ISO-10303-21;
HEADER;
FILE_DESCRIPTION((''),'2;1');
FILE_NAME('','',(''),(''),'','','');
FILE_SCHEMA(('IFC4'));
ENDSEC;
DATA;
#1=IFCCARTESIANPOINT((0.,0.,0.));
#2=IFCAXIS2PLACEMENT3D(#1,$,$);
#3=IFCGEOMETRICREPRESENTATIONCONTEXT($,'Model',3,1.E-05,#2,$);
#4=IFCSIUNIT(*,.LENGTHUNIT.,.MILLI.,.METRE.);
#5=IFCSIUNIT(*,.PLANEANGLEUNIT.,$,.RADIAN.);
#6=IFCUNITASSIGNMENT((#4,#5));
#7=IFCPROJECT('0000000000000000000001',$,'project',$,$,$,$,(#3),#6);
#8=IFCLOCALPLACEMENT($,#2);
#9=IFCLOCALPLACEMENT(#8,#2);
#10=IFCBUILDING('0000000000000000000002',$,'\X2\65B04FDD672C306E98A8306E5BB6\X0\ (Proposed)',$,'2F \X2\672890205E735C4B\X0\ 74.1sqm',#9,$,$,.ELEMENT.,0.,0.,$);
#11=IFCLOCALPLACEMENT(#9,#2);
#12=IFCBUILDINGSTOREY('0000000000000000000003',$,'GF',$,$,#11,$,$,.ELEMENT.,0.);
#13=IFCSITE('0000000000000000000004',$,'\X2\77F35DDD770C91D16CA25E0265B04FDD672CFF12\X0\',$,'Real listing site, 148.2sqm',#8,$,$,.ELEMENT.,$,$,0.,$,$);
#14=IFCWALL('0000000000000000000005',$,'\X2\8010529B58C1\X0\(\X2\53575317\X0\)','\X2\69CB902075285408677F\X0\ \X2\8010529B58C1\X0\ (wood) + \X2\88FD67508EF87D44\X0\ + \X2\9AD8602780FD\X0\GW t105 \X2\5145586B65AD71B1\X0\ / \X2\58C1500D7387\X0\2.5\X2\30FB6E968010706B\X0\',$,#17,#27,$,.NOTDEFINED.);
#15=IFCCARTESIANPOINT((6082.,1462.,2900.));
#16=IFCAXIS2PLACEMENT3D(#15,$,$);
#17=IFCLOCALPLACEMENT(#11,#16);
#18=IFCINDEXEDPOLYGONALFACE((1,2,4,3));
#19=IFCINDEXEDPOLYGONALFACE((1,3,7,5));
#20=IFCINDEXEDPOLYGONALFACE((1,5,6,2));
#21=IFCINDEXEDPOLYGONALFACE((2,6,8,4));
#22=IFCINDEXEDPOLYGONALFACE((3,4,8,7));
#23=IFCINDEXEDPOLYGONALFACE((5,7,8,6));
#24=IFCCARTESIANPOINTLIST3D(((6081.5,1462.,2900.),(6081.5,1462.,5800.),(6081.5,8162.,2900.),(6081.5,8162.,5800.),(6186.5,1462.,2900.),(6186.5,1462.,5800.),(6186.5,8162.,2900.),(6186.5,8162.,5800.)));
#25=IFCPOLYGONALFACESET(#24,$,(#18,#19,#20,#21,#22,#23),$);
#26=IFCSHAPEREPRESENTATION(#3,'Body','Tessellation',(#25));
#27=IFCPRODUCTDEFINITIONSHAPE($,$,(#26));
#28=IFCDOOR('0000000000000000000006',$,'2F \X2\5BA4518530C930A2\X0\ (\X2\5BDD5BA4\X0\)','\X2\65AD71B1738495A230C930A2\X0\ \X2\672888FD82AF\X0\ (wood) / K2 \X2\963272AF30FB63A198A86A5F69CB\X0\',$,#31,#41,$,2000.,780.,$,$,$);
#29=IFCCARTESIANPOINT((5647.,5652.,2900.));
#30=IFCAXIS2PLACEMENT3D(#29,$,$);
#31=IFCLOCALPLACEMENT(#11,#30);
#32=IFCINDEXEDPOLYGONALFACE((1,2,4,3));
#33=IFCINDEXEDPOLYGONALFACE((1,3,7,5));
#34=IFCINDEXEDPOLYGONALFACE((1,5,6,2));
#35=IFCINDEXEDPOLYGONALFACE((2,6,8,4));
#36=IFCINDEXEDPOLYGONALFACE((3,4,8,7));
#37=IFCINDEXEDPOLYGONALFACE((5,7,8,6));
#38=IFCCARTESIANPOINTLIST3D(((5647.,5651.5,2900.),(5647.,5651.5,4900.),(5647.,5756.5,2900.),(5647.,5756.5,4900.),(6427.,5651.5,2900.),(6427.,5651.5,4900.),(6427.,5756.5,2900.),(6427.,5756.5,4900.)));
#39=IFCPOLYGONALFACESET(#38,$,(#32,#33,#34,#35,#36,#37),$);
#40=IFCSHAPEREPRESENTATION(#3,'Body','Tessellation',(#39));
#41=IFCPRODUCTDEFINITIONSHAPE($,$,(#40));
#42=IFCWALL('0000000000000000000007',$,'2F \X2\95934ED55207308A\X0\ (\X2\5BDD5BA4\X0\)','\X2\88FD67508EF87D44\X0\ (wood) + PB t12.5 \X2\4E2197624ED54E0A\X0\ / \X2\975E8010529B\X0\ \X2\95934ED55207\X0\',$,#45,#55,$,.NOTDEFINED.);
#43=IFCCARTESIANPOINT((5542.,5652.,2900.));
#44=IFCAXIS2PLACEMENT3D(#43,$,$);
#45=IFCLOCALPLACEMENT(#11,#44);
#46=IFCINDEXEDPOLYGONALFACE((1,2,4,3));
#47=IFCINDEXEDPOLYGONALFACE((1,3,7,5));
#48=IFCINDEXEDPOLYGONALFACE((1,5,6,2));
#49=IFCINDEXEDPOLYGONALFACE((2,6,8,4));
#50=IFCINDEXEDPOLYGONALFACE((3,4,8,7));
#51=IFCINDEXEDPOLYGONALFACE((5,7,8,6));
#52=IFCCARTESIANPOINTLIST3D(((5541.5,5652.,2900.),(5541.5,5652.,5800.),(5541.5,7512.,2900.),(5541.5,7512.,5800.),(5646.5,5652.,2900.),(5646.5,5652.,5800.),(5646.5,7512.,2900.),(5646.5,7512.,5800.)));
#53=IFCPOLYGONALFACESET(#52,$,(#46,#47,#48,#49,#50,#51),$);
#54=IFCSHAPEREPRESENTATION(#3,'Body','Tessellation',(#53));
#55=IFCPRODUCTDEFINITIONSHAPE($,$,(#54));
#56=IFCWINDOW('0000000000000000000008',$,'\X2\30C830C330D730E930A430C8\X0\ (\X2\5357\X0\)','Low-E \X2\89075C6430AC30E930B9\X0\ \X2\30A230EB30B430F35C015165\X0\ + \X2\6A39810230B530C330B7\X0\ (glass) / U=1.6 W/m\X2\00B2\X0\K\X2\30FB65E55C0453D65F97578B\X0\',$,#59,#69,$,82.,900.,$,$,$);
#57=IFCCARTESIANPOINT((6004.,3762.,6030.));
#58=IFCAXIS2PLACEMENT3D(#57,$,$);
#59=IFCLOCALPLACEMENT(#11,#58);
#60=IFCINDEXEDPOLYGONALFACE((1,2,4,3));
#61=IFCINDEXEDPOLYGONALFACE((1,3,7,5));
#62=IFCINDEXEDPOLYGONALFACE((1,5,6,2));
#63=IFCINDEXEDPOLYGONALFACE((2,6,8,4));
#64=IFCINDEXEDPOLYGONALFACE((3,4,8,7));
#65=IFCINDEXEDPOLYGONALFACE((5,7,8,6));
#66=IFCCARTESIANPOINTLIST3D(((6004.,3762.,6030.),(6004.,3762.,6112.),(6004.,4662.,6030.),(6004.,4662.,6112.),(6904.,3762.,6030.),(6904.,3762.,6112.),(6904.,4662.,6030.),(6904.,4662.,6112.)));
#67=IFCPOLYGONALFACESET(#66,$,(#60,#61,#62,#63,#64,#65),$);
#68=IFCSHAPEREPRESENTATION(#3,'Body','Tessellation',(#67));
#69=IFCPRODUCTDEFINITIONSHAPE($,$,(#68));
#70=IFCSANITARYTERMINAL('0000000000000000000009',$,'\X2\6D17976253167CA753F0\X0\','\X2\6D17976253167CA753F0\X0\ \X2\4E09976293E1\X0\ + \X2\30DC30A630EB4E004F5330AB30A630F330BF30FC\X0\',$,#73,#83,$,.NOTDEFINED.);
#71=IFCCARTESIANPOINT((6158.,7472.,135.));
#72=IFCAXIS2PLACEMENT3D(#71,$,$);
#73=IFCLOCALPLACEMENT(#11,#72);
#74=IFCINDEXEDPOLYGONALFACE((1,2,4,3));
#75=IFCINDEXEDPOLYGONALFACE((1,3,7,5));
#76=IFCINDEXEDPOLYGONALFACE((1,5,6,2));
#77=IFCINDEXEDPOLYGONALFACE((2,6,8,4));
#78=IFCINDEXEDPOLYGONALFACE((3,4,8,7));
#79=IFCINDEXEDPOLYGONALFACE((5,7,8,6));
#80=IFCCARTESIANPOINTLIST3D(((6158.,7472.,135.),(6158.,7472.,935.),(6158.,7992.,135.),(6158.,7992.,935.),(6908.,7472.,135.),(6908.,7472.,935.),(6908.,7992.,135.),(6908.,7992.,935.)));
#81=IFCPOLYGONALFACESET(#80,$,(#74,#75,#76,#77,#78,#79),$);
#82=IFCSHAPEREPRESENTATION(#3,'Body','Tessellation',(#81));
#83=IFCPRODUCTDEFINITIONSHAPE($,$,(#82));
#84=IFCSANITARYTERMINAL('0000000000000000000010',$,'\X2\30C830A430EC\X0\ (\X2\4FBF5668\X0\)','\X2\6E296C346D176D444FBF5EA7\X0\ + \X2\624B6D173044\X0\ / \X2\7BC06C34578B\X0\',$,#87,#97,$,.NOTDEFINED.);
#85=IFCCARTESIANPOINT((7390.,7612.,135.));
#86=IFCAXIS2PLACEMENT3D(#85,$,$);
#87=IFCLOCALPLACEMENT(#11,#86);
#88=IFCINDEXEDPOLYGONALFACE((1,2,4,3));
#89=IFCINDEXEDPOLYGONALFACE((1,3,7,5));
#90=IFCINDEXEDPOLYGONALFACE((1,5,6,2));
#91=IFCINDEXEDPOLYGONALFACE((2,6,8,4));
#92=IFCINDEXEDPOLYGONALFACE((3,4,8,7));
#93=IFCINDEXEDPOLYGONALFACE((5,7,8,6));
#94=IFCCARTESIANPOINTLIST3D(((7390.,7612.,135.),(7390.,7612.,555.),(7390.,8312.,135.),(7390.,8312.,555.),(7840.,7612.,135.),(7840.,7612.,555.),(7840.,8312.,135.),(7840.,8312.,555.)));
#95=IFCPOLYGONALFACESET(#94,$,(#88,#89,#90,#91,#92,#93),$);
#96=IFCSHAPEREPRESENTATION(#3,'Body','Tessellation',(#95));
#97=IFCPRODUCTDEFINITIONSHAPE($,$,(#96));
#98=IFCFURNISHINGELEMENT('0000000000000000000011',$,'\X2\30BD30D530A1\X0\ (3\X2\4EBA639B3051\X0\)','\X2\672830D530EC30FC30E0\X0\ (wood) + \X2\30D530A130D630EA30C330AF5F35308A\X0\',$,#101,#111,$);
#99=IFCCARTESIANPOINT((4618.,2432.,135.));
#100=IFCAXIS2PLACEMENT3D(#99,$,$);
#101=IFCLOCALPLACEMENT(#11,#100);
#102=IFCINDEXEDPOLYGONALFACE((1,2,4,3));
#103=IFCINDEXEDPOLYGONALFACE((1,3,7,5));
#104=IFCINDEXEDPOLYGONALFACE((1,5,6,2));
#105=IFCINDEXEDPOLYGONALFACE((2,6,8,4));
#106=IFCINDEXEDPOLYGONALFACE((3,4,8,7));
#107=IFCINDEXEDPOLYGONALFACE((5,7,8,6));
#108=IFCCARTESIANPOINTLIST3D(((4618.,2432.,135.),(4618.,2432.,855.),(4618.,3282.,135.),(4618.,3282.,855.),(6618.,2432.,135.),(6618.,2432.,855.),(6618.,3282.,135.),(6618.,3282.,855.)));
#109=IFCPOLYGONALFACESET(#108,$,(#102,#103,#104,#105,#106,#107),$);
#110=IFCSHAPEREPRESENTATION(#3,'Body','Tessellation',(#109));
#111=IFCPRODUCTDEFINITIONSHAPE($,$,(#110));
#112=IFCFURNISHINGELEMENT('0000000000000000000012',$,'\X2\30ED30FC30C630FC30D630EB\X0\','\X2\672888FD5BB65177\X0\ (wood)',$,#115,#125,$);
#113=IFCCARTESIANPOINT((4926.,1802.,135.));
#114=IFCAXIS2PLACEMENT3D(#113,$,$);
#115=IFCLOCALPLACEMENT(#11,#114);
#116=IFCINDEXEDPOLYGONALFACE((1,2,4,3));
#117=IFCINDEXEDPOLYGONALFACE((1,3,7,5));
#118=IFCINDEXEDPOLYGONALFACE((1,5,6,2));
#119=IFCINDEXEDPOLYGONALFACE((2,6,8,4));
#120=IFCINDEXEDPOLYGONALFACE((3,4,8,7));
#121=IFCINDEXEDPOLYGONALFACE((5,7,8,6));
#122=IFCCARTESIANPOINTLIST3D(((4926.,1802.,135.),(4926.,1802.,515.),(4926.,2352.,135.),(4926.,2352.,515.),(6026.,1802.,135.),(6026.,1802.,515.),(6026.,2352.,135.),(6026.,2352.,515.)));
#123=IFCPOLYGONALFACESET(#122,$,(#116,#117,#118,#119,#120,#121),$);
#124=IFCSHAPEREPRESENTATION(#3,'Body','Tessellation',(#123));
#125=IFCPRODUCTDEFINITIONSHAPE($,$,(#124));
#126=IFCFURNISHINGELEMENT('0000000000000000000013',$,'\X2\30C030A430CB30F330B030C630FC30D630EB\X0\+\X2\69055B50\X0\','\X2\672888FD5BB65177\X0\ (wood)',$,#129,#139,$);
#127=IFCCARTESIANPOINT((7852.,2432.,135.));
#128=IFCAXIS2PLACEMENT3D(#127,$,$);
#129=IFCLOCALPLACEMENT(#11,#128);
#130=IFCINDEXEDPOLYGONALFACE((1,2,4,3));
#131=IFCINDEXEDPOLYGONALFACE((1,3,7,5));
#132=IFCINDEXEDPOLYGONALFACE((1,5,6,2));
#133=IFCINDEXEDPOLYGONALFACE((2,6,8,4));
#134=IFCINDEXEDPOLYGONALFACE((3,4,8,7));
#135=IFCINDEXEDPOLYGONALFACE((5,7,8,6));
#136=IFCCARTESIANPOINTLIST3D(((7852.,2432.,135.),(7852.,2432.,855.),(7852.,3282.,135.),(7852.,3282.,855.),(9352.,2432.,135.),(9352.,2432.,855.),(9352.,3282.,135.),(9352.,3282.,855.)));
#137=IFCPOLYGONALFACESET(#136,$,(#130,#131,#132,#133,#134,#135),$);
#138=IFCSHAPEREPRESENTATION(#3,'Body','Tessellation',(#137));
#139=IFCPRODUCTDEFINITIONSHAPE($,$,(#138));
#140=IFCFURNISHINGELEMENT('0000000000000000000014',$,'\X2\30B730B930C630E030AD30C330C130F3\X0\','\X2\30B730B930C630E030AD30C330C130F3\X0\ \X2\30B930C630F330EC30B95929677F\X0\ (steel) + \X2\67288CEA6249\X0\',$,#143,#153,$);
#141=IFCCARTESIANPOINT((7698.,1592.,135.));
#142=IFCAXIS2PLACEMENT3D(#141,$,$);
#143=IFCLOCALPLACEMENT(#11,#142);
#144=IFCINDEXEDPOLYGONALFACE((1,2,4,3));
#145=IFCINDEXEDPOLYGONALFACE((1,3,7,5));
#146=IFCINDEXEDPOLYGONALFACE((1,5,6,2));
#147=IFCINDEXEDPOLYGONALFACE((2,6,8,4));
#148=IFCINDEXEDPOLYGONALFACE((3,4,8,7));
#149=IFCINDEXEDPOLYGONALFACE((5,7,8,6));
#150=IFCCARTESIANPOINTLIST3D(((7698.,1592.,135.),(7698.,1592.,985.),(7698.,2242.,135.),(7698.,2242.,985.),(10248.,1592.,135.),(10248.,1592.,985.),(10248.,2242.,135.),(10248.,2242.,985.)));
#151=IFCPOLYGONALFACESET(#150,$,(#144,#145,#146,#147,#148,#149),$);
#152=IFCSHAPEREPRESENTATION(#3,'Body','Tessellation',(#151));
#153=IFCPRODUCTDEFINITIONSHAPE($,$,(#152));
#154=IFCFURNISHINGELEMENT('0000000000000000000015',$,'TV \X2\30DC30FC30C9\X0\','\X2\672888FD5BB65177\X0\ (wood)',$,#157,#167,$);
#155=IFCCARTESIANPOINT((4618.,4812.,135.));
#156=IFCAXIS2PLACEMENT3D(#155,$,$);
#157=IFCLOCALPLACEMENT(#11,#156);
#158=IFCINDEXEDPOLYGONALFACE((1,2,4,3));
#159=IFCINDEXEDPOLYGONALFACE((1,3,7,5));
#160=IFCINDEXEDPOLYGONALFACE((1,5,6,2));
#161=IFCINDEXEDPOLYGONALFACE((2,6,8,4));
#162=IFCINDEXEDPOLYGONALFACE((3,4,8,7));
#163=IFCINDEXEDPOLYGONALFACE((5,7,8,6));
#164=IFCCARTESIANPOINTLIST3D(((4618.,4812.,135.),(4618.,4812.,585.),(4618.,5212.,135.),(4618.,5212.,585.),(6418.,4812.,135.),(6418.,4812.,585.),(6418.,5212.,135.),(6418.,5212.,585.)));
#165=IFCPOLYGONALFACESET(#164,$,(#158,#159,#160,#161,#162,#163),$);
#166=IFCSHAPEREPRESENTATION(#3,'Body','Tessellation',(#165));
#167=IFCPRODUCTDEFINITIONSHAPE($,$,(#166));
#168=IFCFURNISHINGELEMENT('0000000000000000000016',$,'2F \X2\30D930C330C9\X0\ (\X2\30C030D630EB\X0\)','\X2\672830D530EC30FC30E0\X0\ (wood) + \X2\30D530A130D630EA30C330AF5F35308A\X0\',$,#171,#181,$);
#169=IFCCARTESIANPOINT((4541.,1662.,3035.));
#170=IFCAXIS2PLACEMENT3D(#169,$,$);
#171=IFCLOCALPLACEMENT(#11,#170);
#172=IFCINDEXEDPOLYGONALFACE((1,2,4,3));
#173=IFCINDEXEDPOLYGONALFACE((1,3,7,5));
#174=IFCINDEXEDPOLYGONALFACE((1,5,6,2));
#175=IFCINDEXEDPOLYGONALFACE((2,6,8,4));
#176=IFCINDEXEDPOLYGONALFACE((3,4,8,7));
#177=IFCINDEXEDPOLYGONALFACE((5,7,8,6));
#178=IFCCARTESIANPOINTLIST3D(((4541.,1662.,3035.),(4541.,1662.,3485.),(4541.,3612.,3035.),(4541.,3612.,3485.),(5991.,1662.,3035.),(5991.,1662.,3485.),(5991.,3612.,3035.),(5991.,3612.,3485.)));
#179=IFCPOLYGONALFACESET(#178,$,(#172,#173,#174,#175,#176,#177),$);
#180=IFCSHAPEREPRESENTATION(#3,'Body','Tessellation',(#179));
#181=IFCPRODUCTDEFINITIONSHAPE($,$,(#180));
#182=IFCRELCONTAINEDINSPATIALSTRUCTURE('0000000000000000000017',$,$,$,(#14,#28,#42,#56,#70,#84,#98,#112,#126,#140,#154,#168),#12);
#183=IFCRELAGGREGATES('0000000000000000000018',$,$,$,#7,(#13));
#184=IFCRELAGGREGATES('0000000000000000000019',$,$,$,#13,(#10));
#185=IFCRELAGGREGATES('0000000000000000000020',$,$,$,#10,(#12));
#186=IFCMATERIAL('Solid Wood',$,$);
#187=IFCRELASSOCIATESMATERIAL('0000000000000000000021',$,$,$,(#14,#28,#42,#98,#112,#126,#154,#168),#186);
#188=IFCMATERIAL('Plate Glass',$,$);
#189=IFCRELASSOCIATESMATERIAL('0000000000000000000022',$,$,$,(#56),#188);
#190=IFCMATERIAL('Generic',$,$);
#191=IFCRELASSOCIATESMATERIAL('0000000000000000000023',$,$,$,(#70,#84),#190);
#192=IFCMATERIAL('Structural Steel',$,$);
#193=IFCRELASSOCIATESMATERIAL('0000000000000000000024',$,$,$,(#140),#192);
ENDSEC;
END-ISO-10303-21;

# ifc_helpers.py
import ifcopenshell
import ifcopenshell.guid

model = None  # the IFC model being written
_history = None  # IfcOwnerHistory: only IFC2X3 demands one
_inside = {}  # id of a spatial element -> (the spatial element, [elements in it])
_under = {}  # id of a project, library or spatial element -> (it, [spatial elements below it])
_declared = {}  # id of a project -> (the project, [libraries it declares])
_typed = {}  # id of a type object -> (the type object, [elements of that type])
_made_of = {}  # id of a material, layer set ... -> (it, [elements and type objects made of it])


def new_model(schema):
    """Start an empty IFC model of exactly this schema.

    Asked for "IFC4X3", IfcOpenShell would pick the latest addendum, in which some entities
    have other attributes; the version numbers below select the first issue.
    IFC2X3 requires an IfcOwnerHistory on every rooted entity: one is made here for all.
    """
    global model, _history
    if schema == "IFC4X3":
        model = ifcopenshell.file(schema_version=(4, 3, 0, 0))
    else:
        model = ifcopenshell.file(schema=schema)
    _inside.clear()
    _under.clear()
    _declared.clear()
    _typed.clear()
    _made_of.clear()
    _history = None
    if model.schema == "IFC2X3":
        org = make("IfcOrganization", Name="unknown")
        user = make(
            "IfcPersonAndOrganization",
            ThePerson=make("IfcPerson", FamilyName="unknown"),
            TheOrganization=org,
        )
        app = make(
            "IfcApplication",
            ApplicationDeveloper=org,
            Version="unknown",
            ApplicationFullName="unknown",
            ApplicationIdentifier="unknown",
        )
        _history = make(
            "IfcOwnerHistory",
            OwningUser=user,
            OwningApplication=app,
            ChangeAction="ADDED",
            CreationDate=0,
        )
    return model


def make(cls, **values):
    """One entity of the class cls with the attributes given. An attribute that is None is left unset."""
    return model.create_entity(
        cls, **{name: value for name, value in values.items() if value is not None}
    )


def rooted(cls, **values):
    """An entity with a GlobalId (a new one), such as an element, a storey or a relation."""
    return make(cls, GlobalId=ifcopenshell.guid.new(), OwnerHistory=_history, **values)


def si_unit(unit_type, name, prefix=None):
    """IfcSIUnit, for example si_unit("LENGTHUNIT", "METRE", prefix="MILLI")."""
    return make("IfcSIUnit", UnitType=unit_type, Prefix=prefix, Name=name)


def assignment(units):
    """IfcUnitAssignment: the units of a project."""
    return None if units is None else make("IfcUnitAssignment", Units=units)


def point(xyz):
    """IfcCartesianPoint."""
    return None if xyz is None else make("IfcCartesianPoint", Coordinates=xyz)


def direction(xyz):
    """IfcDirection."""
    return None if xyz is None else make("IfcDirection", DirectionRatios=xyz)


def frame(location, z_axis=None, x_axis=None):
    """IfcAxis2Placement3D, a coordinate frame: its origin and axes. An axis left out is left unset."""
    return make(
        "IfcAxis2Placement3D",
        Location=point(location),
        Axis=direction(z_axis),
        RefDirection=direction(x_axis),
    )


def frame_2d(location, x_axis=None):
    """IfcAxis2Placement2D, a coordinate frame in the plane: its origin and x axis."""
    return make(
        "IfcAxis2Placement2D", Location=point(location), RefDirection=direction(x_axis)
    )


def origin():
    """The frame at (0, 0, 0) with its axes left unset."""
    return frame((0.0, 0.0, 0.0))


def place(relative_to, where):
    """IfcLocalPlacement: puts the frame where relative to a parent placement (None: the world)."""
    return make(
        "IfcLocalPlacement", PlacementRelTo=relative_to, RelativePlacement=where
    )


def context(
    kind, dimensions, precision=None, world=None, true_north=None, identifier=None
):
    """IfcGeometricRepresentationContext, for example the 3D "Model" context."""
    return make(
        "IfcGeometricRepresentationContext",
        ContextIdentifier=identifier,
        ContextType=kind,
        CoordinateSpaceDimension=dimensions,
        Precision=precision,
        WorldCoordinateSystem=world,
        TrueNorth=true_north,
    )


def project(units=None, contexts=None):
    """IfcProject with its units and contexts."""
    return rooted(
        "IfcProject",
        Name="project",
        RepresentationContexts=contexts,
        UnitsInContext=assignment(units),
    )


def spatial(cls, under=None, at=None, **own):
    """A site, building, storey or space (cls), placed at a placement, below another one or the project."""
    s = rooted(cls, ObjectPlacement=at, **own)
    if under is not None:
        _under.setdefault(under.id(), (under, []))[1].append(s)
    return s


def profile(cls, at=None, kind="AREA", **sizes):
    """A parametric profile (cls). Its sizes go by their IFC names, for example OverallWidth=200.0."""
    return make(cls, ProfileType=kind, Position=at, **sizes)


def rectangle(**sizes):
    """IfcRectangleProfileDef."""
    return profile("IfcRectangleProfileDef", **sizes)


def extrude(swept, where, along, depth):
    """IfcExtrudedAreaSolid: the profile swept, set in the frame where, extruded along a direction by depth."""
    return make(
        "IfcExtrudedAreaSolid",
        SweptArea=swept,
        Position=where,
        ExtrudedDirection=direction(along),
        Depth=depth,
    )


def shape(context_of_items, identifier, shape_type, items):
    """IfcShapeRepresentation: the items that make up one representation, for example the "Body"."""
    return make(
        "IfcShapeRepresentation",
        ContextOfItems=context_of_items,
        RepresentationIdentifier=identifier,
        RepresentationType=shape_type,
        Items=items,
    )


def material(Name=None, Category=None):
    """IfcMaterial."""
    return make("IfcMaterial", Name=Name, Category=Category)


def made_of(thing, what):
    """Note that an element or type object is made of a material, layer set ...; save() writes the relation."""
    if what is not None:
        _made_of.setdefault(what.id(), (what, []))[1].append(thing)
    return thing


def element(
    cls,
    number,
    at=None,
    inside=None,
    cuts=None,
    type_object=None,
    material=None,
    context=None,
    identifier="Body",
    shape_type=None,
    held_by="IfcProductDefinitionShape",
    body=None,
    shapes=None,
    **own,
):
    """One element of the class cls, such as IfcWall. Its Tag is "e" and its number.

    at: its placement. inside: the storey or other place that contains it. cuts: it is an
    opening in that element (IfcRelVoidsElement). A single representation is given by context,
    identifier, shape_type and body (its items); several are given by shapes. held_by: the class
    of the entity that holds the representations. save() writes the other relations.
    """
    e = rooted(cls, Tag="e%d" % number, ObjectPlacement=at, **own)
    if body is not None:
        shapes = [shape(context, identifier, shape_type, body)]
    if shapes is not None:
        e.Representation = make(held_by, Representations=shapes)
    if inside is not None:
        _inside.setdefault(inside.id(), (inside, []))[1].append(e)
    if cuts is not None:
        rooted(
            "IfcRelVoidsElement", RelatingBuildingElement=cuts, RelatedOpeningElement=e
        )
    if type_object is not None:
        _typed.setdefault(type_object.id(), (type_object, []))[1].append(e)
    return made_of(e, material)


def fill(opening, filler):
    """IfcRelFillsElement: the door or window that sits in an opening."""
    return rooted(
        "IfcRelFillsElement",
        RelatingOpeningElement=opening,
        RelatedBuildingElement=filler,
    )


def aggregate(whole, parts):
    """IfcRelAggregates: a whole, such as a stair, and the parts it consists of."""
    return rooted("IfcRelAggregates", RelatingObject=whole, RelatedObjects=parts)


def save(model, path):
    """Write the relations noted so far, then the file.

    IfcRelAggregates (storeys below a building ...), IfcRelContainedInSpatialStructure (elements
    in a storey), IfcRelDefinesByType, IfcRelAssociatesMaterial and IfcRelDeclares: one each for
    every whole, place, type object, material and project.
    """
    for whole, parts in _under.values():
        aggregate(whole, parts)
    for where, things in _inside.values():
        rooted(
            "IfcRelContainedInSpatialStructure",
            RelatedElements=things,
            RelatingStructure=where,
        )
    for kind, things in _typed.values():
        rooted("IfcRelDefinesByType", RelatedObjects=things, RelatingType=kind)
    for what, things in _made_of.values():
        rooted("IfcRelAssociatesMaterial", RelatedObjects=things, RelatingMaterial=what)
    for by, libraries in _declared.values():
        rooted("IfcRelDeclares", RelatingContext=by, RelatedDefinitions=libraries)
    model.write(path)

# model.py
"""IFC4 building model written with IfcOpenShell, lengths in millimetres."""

from ifc_helpers import new_model, si_unit, frame, frame_2d, origin, place, context, project, spatial, rectangle, extrude, material, element, fill, save


model = new_model("IFC4")

# Units and contexts
model_context = context("Model", 3, precision=1e-05, world=origin())
ifc_project = project(units=[si_unit("LENGTHUNIT", "METRE", prefix="MILLI"), si_unit("PLANEANGLEUNIT", "RADIAN")], contexts=[model_context])

# Site, building, storey
site_placement = place(None, origin())
site = spatial("IfcSite", under=ifc_project, at=site_placement, Name="石川県金沢市新保本２", ObjectType="Real listing site, 148.2sqm", CompositionType="ELEMENT", RefElevation=0.0)
building_placement = place(site_placement, origin())
building = spatial("IfcBuilding", under=site, at=building_placement, Name="新保本の風の家 (Proposed)", ObjectType="2F 木造平屋 74.1sqm", CompositionType="ELEMENT", ElevationOfRefHeight=0.0, ElevationOfTerrain=0.0)
storey_placement = place(building_placement, origin())
storey = spatial("IfcBuildingStorey", under=building, at=storey_placement, Name="GF", CompositionType="ELEMENT", Elevation=0.0)

# Shared definitions
ifc_material_1 = material(Name="Solid Wood")

# Wall, opening, door
wall_1_placement = place(storey_placement, frame((6082.0, 1462.0, 2900.0)))
wall_1 = element("IfcWall", 1, at=wall_1_placement, inside=storey, material=ifc_material_1, Name="耐力壁(南北)", Description="構造用合板 耐力壁 (wood) + 製材軸組 + 高性能GW t105 充填断熱 / 壁倍率2.5・準耐火", PredefinedType="NOTDEFINED", context=model_context, shape_type="SweptSolid", body=[
    extrude(rectangle(XDim=105.0, YDim=6700.0, at=frame_2d((52.0, 3350.0))), frame((6082.0, 1462.0, 2900.0)), (0.0, 0.0, 1.0), 2900.0),
])
opening_1_placement = place(storey_placement, frame((5647.0, 5652.0, 2900.0)))
opening_1 = element("IfcOpeningElement", 2, at=opening_1_placement, cuts=wall_1, PredefinedType="NOTDEFINED", context=model_context, shape_type="SweptSolid", body=[
    extrude(rectangle(XDim=780.0, YDim=105.0, at=frame_2d((390.0, 52.0))), frame((5647.0, 5652.0, 2900.0)), (0.0, 0.0, 1.0), 2000.0),
])
door_1_placement = place(storey_placement, frame((5647.0, 5652.0, 2900.0)))
door_1 = element("IfcDoor", 3, at=door_1_placement, inside=storey, material=ifc_material_1, Name="2F 室内ドア (寝室)", Description="断熱玄関ドア 木製芯 (wood) / K2 防犯・採風機構", OverallHeight=2000.0, OverallWidth=780.0, context=model_context, shape_type="SweptSolid", body=[
    extrude(rectangle(XDim=780.0, YDim=105.0, at=frame_2d((390.0, 52.0))), frame((5647.0, 5652.0, 2900.0)), (0.0, 0.0, 1.0), 2000.0),
])
fill(opening_1, door_1)

# Wall
wall_2_placement = place(storey_placement, frame((5542.0, 5652.0, 2900.0)))
element("IfcWall", 4, at=wall_2_placement, inside=storey, material=ifc_material_1, Name="2F 間仕切り (寝室)", Description="製材軸組 (wood) + PB t12.5 両面仕上 / 非耐力 間仕切", PredefinedType="NOTDEFINED", context=model_context, shape_type="SweptSolid", body=[
    extrude(rectangle(XDim=105.0, YDim=1860.0, at=frame_2d((52.0, 930.0))), frame((5542.0, 5652.0, 2900.0)), (0.0, 0.0, 1.0), 2900.0),
])

# Window
ifc_material_2 = material(Name="Plate Glass")
window_placement = place(storey_placement, frame((6004.0, 3762.0, 6030.0)))
element("IfcWindow", 5, at=window_placement, inside=storey, material=ifc_material_2, Name="トップライト (南)", Description="Low-E 複層ガラス アルゴン封入 + 樹脂サッシ (glass) / U=1.6 W/m²K・日射取得型", OverallHeight=82.0, OverallWidth=900.0, context=model_context, shape_type="SweptSolid", body=[
    extrude(rectangle(XDim=900.0, YDim=900.0, at=frame_2d((450.0, 450.0))), frame((6004.0, 3762.0, 6030.0)), (0.0, 0.0, 1.0), 82.0),
])

# Sanitary terminals
ifc_material_3 = material(Name="Generic")
sanitary_terminal_1_placement = place(storey_placement, frame((6158.0, 7472.0, 135.0)))
element("IfcSanitaryTerminal", 6, at=sanitary_terminal_1_placement, inside=storey, material=ifc_material_3, Name="洗面化粧台", Description="洗面化粧台 三面鏡 + ボウル一体カウンター", PredefinedType="NOTDEFINED", context=model_context, shape_type="SweptSolid", body=[
    extrude(rectangle(XDim=750.0, YDim=520.0, at=frame_2d((375.0, 260.0))), frame((6158.0, 7472.0, 135.0)), (0.0, 0.0, 1.0), 800.0),
])
sanitary_terminal_2_placement = place(storey_placement, frame((7390.0, 7612.0, 135.0)))
element("IfcSanitaryTerminal", 7, at=sanitary_terminal_2_placement, inside=storey, material=ifc_material_3, Name="トイレ (便器)", Description="温水洗浄便座 + 手洗い / 節水型", PredefinedType="NOTDEFINED", context=model_context, shape_type="SweptSolid", body=[
    extrude(rectangle(XDim=450.0, YDim=700.0, at=frame_2d((225.0, 350.0))), frame((7390.0, 7612.0, 135.0)), (0.0, 0.0, 1.0), 420.0),
])

# Furnishing elements
furnishing_1_placement = place(storey_placement, frame((4618.0, 2432.0, 135.0)))
element("IfcFurnishingElement", 8, at=furnishing_1_placement, inside=storey, material=ifc_material_1, Name="ソファ (3人掛け)", Description="木フレーム (wood) + ファブリック張り", context=model_context, shape_type="SweptSolid", body=[
    extrude(rectangle(XDim=2000.0, YDim=850.0, at=frame_2d((1000.0, 425.0))), frame((4618.0, 2432.0, 135.0)), (0.0, 0.0, 1.0), 720.0),
])
furnishing_2_placement = place(storey_placement, frame((4926.0, 1802.0, 135.0)))
element("IfcFurnishingElement", 9, at=furnishing_2_placement, inside=storey, material=ifc_material_1, Name="ローテーブル", Description="木製家具 (wood)", context=model_context, shape_type="SweptSolid", body=[
    extrude(rectangle(XDim=1100.0, YDim=550.0, at=frame_2d((550.0, 275.0))), frame((4926.0, 1802.0, 135.0)), (0.0, 0.0, 1.0), 380.0),
])
furnishing_3_placement = place(storey_placement, frame((7852.0, 2432.0, 135.0)))
element("IfcFurnishingElement", 10, at=furnishing_3_placement, inside=storey, material=ifc_material_1, Name="ダイニングテーブル+椅子", Description="木製家具 (wood)", context=model_context, shape_type="SweptSolid", body=[
    extrude(rectangle(XDim=1500.0, YDim=850.0, at=frame_2d((750.0, 425.0))), frame((7852.0, 2432.0, 135.0)), (0.0, 0.0, 1.0), 720.0),
])
ifc_material_4 = material(Name="Structural Steel")
furnishing_4_placement = place(storey_placement, frame((7698.0, 1592.0, 135.0)))
element("IfcFurnishingElement", 11, at=furnishing_4_placement, inside=storey, material=ifc_material_4, Name="システムキッチン", Description="システムキッチン ステンレス天板 (steel) + 木質扉", context=model_context, shape_type="SweptSolid", body=[
    extrude(rectangle(XDim=2550.0, YDim=650.0, at=frame_2d((1275.0, 325.0))), frame((7698.0, 1592.0, 135.0)), (0.0, 0.0, 1.0), 850.0),
])
furnishing_5_placement = place(storey_placement, frame((4618.0, 4812.0, 135.0)))
element("IfcFurnishingElement", 12, at=furnishing_5_placement, inside=storey, material=ifc_material_1, Name="TV ボード", Description="木製家具 (wood)", context=model_context, shape_type="SweptSolid", body=[
    extrude(rectangle(XDim=1800.0, YDim=400.0, at=frame_2d((900.0, 200.0))), frame((4618.0, 4812.0, 135.0)), (0.0, 0.0, 1.0), 450.0),
])
furnishing_6_placement = place(storey_placement, frame((4541.0, 1662.0, 3035.0)))
element("IfcFurnishingElement", 13, at=furnishing_6_placement, inside=storey, material=ifc_material_1, Name="2F ベッド (ダブル)", Description="木フレーム (wood) + ファブリック張り", context=model_context, shape_type="SweptSolid", body=[
    extrude(rectangle(XDim=1450.0, YDim=1950.0, at=frame_2d((725.0, 975.0))), frame((4541.0, 1662.0, 3035.0)), (0.0, 0.0, 1.0), 450.0),
])

save(model, "model.ifc")
